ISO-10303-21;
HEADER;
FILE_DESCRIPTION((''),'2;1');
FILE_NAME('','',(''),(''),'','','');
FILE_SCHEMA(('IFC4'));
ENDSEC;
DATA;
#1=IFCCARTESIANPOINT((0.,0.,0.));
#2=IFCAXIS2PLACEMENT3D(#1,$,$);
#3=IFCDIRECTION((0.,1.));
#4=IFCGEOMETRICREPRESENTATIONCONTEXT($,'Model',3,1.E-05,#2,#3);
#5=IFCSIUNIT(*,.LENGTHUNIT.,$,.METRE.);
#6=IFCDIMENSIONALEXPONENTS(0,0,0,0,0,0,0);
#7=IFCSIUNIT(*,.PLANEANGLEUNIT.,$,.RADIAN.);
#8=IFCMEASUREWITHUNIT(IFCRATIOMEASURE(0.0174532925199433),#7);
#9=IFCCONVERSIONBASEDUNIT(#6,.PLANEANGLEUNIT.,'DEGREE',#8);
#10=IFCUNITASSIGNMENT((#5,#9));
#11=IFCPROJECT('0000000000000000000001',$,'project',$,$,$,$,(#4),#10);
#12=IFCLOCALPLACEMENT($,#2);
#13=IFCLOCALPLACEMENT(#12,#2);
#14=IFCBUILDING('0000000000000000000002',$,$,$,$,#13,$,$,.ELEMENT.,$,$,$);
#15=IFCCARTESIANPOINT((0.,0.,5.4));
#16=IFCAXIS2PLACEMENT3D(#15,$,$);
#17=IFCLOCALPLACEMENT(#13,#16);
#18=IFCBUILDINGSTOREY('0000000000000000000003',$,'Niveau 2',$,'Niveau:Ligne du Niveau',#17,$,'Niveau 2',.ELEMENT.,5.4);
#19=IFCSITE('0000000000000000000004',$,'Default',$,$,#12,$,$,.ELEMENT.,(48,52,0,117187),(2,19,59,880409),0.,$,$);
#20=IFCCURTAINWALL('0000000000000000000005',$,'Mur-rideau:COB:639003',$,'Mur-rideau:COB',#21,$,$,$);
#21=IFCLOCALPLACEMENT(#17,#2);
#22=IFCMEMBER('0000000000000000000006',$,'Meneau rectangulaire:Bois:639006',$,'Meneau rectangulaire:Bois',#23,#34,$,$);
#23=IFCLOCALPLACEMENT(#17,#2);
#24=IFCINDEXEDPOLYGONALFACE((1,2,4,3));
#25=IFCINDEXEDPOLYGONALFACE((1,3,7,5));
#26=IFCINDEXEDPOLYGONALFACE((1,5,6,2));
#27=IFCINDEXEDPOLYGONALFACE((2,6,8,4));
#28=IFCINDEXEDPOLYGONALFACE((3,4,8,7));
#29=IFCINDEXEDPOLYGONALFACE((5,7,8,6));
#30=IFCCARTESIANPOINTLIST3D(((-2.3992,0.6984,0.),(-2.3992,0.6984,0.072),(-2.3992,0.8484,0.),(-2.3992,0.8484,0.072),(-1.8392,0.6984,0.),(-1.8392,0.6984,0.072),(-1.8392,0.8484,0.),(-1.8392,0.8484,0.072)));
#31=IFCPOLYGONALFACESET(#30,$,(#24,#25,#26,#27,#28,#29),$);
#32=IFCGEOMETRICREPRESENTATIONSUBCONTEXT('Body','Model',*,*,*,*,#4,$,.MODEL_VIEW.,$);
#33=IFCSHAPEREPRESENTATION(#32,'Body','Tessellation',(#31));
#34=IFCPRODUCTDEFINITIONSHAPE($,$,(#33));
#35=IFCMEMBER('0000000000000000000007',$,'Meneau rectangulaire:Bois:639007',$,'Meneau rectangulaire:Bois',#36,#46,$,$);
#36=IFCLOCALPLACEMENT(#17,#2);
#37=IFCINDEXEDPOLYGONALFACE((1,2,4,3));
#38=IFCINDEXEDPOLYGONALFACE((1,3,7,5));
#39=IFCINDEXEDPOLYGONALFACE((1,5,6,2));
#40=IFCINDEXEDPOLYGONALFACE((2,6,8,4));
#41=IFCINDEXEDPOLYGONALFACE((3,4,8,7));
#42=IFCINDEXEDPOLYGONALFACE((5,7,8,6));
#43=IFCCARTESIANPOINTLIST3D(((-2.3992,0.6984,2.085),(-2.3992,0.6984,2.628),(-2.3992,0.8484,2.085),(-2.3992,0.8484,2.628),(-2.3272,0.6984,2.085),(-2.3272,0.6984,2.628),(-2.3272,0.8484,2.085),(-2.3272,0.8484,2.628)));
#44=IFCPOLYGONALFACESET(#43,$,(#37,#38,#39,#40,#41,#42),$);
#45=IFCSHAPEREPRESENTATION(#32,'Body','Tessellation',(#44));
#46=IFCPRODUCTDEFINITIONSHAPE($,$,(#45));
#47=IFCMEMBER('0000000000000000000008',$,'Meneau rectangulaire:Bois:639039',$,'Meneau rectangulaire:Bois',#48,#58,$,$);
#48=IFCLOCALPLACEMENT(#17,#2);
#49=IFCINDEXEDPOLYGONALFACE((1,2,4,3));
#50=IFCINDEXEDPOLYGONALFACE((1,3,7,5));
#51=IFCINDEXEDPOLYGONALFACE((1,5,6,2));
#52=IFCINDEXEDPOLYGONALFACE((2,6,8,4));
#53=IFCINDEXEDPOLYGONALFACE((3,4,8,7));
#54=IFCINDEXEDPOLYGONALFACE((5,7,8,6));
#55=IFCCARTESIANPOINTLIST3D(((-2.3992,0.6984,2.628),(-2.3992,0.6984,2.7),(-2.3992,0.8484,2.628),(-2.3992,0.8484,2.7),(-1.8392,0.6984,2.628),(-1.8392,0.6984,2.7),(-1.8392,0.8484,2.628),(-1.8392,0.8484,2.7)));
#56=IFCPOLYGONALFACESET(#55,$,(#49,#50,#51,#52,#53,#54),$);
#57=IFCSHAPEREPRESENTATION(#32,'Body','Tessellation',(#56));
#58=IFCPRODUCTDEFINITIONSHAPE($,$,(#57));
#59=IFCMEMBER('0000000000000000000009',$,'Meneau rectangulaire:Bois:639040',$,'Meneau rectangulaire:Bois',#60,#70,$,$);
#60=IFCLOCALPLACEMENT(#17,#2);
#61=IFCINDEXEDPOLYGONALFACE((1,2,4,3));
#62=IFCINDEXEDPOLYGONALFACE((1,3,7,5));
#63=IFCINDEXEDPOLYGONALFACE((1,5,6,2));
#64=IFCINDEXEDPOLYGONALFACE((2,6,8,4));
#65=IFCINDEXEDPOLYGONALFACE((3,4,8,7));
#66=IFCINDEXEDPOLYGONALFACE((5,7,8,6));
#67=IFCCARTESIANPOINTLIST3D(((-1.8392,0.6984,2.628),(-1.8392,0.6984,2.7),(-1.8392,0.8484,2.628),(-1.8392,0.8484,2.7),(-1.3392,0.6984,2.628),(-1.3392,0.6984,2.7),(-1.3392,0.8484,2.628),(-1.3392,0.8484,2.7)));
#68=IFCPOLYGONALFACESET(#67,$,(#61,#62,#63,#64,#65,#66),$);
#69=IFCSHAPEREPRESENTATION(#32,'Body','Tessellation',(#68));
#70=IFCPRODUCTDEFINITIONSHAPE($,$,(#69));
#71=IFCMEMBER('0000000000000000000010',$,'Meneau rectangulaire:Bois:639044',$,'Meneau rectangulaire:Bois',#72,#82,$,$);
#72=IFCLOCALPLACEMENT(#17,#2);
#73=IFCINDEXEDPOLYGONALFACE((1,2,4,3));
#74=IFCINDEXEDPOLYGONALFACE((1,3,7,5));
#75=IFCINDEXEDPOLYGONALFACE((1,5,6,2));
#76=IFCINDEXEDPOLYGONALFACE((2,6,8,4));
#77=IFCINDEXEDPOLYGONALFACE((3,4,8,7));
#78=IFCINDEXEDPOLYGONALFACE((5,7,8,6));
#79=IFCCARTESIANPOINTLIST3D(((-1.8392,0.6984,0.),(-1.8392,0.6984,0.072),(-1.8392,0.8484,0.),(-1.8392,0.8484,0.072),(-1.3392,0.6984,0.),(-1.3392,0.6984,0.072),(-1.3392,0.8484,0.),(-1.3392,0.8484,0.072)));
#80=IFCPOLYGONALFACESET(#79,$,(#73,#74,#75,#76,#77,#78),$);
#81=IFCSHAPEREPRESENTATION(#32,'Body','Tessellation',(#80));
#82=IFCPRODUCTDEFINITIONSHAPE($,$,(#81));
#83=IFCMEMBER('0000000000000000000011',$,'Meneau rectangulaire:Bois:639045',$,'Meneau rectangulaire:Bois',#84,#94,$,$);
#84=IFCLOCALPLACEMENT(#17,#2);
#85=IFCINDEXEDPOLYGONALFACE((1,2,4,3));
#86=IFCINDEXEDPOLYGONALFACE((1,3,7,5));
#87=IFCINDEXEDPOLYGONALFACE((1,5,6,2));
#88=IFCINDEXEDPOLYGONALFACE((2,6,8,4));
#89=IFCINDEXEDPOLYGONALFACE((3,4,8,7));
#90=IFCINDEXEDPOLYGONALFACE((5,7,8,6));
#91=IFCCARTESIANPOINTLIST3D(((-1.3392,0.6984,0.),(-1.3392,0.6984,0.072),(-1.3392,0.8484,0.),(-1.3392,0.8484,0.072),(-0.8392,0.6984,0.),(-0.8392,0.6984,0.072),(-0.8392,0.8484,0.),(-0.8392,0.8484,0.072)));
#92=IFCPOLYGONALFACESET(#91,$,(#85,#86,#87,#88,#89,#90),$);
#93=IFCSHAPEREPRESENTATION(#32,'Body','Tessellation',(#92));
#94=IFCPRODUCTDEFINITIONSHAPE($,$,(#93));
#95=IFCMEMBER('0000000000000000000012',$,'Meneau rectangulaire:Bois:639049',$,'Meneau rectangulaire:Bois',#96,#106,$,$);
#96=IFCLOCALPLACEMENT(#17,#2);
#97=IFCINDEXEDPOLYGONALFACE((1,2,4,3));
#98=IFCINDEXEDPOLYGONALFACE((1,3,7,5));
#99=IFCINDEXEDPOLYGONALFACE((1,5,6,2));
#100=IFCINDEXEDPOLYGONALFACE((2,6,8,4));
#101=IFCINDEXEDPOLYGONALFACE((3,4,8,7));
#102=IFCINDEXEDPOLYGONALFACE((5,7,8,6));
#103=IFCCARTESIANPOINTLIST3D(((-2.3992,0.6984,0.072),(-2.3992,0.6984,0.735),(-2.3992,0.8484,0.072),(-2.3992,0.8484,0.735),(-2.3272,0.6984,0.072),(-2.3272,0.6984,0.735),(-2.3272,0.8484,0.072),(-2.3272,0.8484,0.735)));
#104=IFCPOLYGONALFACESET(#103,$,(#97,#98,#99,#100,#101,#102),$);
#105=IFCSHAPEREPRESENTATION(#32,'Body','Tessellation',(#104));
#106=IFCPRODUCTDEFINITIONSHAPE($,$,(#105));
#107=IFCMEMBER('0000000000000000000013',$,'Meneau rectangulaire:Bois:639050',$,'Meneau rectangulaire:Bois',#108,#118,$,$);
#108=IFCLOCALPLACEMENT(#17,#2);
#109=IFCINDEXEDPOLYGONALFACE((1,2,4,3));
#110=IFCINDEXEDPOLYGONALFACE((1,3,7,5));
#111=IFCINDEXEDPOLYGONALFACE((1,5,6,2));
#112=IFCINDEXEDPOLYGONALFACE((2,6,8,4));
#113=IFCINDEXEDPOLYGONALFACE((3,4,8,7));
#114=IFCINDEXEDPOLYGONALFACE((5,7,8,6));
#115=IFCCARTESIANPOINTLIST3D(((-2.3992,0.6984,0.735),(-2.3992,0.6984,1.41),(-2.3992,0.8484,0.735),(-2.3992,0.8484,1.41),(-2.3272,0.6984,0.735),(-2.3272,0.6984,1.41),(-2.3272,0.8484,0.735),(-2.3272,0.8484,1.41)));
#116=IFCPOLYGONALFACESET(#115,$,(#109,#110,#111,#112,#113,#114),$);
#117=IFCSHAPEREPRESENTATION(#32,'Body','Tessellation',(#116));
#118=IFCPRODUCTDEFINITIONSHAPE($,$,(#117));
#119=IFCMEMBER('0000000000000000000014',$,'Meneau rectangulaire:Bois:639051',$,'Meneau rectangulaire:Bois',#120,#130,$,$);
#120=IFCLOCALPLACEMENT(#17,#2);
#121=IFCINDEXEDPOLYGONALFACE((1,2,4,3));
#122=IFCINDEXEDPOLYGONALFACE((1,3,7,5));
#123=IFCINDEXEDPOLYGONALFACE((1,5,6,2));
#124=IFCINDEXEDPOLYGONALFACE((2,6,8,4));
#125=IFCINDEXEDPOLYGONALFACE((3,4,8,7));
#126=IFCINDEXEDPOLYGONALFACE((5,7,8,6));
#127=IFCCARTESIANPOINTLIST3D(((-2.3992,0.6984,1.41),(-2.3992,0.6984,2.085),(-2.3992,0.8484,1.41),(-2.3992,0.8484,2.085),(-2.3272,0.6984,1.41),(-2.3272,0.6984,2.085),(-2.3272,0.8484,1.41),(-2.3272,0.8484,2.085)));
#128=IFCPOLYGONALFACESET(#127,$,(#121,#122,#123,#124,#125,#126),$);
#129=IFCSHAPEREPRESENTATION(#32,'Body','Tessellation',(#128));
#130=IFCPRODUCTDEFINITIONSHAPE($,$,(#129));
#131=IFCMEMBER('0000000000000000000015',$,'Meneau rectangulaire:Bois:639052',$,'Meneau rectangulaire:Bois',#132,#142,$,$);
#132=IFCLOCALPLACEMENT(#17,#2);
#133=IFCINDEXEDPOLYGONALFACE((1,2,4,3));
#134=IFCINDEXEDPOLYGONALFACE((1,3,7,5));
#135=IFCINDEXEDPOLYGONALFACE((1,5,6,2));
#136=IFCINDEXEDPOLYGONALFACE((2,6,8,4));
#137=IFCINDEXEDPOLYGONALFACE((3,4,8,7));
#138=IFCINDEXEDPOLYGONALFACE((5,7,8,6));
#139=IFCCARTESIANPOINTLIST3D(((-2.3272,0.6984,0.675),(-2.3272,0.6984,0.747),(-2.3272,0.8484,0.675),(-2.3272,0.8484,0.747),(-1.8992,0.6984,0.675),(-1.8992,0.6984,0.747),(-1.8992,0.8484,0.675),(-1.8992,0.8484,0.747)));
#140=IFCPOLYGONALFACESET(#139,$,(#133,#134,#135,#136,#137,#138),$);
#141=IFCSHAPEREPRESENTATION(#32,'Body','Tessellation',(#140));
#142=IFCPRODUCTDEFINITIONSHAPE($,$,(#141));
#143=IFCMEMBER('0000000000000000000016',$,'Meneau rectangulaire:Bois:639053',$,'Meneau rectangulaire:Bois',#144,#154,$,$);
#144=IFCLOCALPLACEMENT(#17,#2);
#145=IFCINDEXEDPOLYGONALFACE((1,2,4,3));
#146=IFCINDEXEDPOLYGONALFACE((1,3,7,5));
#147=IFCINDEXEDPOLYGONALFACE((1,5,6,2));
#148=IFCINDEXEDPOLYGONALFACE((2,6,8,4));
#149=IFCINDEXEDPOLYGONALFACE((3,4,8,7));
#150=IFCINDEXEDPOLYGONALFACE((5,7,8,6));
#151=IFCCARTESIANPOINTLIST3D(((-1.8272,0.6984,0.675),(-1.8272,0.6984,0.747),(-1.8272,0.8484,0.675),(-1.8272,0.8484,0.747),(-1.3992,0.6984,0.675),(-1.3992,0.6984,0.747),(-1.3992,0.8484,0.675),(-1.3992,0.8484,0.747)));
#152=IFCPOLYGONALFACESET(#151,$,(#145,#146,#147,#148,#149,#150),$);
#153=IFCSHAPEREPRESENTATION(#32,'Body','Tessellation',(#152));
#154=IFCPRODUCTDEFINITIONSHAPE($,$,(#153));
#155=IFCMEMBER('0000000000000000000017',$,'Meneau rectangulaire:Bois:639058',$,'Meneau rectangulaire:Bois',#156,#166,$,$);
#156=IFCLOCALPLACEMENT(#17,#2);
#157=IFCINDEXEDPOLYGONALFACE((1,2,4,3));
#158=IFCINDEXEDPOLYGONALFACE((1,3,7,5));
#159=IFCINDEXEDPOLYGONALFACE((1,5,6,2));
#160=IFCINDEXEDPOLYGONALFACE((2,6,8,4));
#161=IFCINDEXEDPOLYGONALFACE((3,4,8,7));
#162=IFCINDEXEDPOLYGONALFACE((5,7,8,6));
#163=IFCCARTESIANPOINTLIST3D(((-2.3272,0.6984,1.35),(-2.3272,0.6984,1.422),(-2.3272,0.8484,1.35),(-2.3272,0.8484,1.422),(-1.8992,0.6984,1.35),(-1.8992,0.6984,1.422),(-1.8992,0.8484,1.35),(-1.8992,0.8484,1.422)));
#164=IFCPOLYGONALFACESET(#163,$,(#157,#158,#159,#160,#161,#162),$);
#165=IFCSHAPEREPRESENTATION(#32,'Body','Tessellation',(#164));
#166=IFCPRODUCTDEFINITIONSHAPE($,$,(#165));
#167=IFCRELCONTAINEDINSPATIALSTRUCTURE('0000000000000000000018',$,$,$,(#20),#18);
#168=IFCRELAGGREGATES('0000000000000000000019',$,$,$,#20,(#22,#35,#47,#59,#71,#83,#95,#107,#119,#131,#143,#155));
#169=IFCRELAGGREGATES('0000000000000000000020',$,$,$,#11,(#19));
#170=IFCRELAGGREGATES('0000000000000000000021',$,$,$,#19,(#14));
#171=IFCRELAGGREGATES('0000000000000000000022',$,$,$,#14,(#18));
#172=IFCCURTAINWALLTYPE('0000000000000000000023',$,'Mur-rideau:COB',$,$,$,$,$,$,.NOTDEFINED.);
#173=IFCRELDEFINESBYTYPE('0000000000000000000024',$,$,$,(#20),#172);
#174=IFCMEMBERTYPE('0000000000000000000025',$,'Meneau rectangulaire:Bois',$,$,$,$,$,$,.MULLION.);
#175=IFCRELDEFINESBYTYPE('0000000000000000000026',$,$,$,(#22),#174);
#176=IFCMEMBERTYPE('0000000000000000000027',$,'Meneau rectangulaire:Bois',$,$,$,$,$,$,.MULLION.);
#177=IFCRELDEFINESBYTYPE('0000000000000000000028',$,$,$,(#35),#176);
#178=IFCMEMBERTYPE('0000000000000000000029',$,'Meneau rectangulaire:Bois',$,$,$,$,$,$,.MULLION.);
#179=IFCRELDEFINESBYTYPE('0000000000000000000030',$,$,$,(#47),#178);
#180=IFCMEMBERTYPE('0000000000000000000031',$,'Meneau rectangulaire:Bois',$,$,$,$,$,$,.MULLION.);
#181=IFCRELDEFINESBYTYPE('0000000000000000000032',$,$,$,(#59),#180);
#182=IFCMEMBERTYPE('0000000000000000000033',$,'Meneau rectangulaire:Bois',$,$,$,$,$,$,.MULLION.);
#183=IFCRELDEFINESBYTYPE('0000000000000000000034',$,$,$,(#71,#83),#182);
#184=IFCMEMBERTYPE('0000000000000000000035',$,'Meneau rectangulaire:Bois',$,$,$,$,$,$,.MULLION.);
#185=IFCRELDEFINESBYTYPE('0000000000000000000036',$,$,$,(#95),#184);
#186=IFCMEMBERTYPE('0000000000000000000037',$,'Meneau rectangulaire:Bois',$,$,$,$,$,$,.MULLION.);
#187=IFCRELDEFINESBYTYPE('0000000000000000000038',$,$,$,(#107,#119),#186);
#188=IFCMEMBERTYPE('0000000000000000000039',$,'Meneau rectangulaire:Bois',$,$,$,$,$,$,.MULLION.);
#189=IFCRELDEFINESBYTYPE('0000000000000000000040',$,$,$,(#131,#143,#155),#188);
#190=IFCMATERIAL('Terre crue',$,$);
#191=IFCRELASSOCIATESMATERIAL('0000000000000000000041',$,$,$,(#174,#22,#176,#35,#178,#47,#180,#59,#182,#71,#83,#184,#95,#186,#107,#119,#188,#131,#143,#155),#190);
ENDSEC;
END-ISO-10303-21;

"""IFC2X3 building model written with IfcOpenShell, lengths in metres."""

from ifc_helpers import new_model, entity, si_unit, converted_unit, direction, frame, origin, origin_2d_with_axis, place, context, subcontext, project, spatial, rectangle, extrude, source, transform, mapped, material, type_object, type_shapes, element, aggregate, save


model = new_model("IFC2X3")

# Units and contexts
model_context = context("Model", 3, precision=1e-05, world=origin(), true_north=direction((0.0, 1.0)))
body_context = subcontext(model_context, "Body", "Model", "MODEL_VIEW")
ifc_project = project(units=[si_unit("LENGTHUNIT", "METRE"), converted_unit("PLANEANGLEUNIT", "DEGREE", entity("IfcRatioMeasure", 0.0174532925199433), si_unit("PLANEANGLEUNIT", "RADIAN"), dimensions=[0, 0, 0, 0, 0, 0, 0])], contexts=[model_context])

# Site, building, storey
site_placement = place(None, origin())
site = spatial("IfcSite", under=ifc_project, at=site_placement, Name="Default", CompositionType="ELEMENT", RefLatitude=(48, 52, 0, 117187), RefLongitude=(2, 19, 59, 880409), RefElevation=0.0)
building_placement = place(site_placement, origin())
building = spatial("IfcBuilding", under=site, at=building_placement, CompositionType="ELEMENT")
storey_placement = place(building_placement, frame((0.0, 0.0, 5.4)))
storey = spatial("IfcBuildingStorey", under=building, at=storey_placement, Name="Niveau 2", ObjectType="Niveau:Ligne du Niveau", LongName="Niveau 2", CompositionType="ELEMENT", Elevation=5.4)

# Curtain wall, members
curtain_wall_type_1 = type_object("IfcCurtainWallType", Name="Mur-rideau:COB", PredefinedType="NOTDEFINED")
curtain_wall_1_placement = place(storey_placement, frame((0.0, 0.0, -5.4)))
curtain_wall_1 = element("IfcCurtainWall", 1, at=curtain_wall_1_placement, inside=storey, type_object=curtain_wall_type_1, Name="Mur-rideau:COB:639003", ObjectType="Mur-rideau:COB")
ifc_material_1 = material(Name="Terre crue")
member_type_1 = type_object("IfcMemberType", Name="Meneau rectangulaire:Bois", PredefinedType="MULLION", material=ifc_material_1)
shared_shape_1 = source(origin(), body_context, "Body", "SweptSolid", [
    extrude(rectangle(XDim=0.15, YDim=0.072, at=origin_2d_with_axis()), frame((-0.036, 0.0, -0.56), z_axis=(0.0, 0.0, 1.0), x_axis=(0.0, -1.0, 0.0)), (0.0, 0.0, 1.0), 0.56),
])
type_shapes(member_type_1, [shared_shape_1])
member_1_placement = place(storey_placement, frame((-2.3992, 0.7734, 0.0), z_axis=(-1.0, 0.0, 0.0), x_axis=(0.0, 0.0, -1.0)))
member_1 = element("IfcMember", 2, at=member_1_placement, type_object=member_type_1, material=ifc_material_1, Name="Meneau rectangulaire:Bois:639006", ObjectType="Meneau rectangulaire:Bois", context=body_context, shape_type="MappedRepresentation", body=[
    mapped(shared_shape_1, transform((0.0, 0.0, 0.0), scale=1.0)),
])
member_type_2 = type_object("IfcMemberType", Name="Meneau rectangulaire:Bois", PredefinedType="MULLION", material=ifc_material_1)
shared_shape_2 = source(origin(), body_context, "Body", "SweptSolid", [
    extrude(rectangle(XDim=0.15, YDim=0.072, at=origin_2d_with_axis()), frame((-0.036, 0.0, -0.543), z_axis=(0.0, 0.0, 1.0), x_axis=(0.0, -1.0, 0.0)), (0.0, 0.0, 1.0), 0.543),
])
type_shapes(member_type_2, [shared_shape_2])
member_2_placement = place(storey_placement, frame((-2.3992, 0.7734, 2.628), z_axis=(0.0, 0.0, 1.0), x_axis=(-1.0, 0.0, 0.0)))
member_2 = element("IfcMember", 3, at=member_2_placement, type_object=member_type_2, material=ifc_material_1, Name="Meneau rectangulaire:Bois:639007", ObjectType="Meneau rectangulaire:Bois", context=body_context, shape_type="MappedRepresentation", body=[
    mapped(shared_shape_2, transform((0.0, 0.0, 0.0), scale=1.0)),
])
member_type_3 = type_object("IfcMemberType", Name="Meneau rectangulaire:Bois", PredefinedType="MULLION", material=ifc_material_1)
shared_shape_3 = source(origin(), body_context, "Body", "SweptSolid", [
    extrude(rectangle(XDim=0.15, YDim=0.072, at=origin_2d_with_axis()), frame((-0.036, 0.0, -0.56), z_axis=(0.0, 0.0, 1.0), x_axis=(0.0, -1.0, 0.0)), (0.0, 0.0, 1.0), 0.56),
])
type_shapes(member_type_3, [shared_shape_3])
member_3_placement = place(storey_placement, frame((-1.8392, 0.7734, 2.7), z_axis=(1.0, 0.0, 0.0), x_axis=(0.0, 0.0, 1.0)))
member_3 = element("IfcMember", 4, at=member_3_placement, type_object=member_type_3, material=ifc_material_1, Name="Meneau rectangulaire:Bois:639039", ObjectType="Meneau rectangulaire:Bois", context=body_context, shape_type="MappedRepresentation", body=[
    mapped(shared_shape_3, transform((0.0, 0.0, 0.0), scale=1.0)),
])
member_type_4 = type_object("IfcMemberType", Name="Meneau rectangulaire:Bois", PredefinedType="MULLION", material=ifc_material_1)
shared_shape_4 = source(origin(), body_context, "Body", "SweptSolid", [
    extrude(rectangle(XDim=0.15, YDim=0.072, at=origin_2d_with_axis()), frame((-0.036, 0.0, -0.5), z_axis=(0.0, 0.0, 1.0), x_axis=(0.0, -1.0, 0.0)), (0.0, 0.0, 1.0), 0.5),
])
type_shapes(member_type_4, [shared_shape_4])
member_4_placement = place(storey_placement, frame((-1.3392, 0.7734, 2.7), z_axis=(1.0, 0.0, 0.0), x_axis=(0.0, 0.0, 1.0)))
member_4 = element("IfcMember", 5, at=member_4_placement, type_object=member_type_4, material=ifc_material_1, Name="Meneau rectangulaire:Bois:639040", ObjectType="Meneau rectangulaire:Bois", context=body_context, shape_type="MappedRepresentation", body=[
    mapped(shared_shape_4, transform((0.0, 0.0, 0.0), scale=1.0)),
])
member_type_5 = type_object("IfcMemberType", Name="Meneau rectangulaire:Bois", PredefinedType="MULLION", material=ifc_material_1)
shared_shape_5 = source(origin(), body_context, "Body", "SweptSolid", [
    extrude(rectangle(XDim=0.15, YDim=0.072, at=origin_2d_with_axis()), frame((-0.036, 0.0, -0.5), z_axis=(0.0, 0.0, 1.0), x_axis=(0.0, -1.0, 0.0)), (0.0, 0.0, 1.0), 0.5),
])
type_shapes(member_type_5, [shared_shape_5])
member_5_placement = place(storey_placement, frame((-1.8392, 0.7734, 0.0), z_axis=(-1.0, 0.0, 0.0), x_axis=(0.0, 0.0, -1.0)))
member_5 = element("IfcMember", 6, at=member_5_placement, type_object=member_type_5, material=ifc_material_1, Name="Meneau rectangulaire:Bois:639044", ObjectType="Meneau rectangulaire:Bois", context=body_context, shape_type="MappedRepresentation", body=[
    mapped(shared_shape_5, transform((0.0, 0.0, 0.0), scale=1.0)),
])
member_6_placement = place(storey_placement, frame((-1.3392, 0.7734, 0.0), z_axis=(-1.0, 0.0, 0.0), x_axis=(0.0, 0.0, -1.0)))
member_6 = element("IfcMember", 7, at=member_6_placement, type_object=member_type_5, material=ifc_material_1, Name="Meneau rectangulaire:Bois:639045", ObjectType="Meneau rectangulaire:Bois", context=body_context, shape_type="MappedRepresentation", body=[
    mapped(shared_shape_5, transform((0.0, 0.0, 0.0), scale=1.0)),
])
member_type_6 = type_object("IfcMemberType", Name="Meneau rectangulaire:Bois", PredefinedType="MULLION", material=ifc_material_1)
shared_shape_6 = source(origin(), body_context, "Body", "SweptSolid", [
    extrude(rectangle(XDim=0.15, YDim=0.072, at=origin_2d_with_axis()), frame((-0.036, 0.0, -0.663), z_axis=(0.0, 0.0, 1.0), x_axis=(0.0, -1.0, 0.0)), (0.0, 0.0, 1.0), 0.663),
])
type_shapes(member_type_6, [shared_shape_6])
member_7_placement = place(storey_placement, frame((-2.3992, 0.7734, 0.735), z_axis=(0.0, 0.0, 1.0), x_axis=(-1.0, 0.0, 0.0)))
member_7 = element("IfcMember", 8, at=member_7_placement, type_object=member_type_6, material=ifc_material_1, Name="Meneau rectangulaire:Bois:639049", ObjectType="Meneau rectangulaire:Bois", context=body_context, shape_type="MappedRepresentation", body=[
    mapped(shared_shape_6, transform((0.0, 0.0, 0.0), scale=1.0)),
])
member_type_7 = type_object("IfcMemberType", Name="Meneau rectangulaire:Bois", PredefinedType="MULLION", material=ifc_material_1)
shared_shape_7 = source(origin(), body_context, "Body", "SweptSolid", [
    extrude(rectangle(XDim=0.15, YDim=0.072, at=origin_2d_with_axis()), frame((-0.036, 0.0, -0.675), z_axis=(0.0, 0.0, 1.0), x_axis=(0.0, -1.0, 0.0)), (0.0, 0.0, 1.0), 0.675),
])
type_shapes(member_type_7, [shared_shape_7])
member_8_placement = place(storey_placement, frame((-2.3992, 0.7734, 1.41), z_axis=(0.0, 0.0, 1.0), x_axis=(-1.0, 0.0, 0.0)))
member_8 = element("IfcMember", 9, at=member_8_placement, type_object=member_type_7, material=ifc_material_1, Name="Meneau rectangulaire:Bois:639050", ObjectType="Meneau rectangulaire:Bois", context=body_context, shape_type="MappedRepresentation", body=[
    mapped(shared_shape_7, transform((0.0, 0.0, 0.0), scale=1.0)),
])
member_9_placement = place(storey_placement, frame((-2.3992, 0.7734, 2.085), z_axis=(0.0, 0.0, 1.0), x_axis=(-1.0, 0.0, 0.0)))
member_9 = element("IfcMember", 10, at=member_9_placement, type_object=member_type_7, material=ifc_material_1, Name="Meneau rectangulaire:Bois:639051", ObjectType="Meneau rectangulaire:Bois", context=body_context, shape_type="MappedRepresentation", body=[
    mapped(shared_shape_7, transform((0.0, 0.0, 0.0), scale=1.0)),
])
member_type_8 = type_object("IfcMemberType", Name="Meneau rectangulaire:Bois", PredefinedType="MULLION", material=ifc_material_1)
shared_shape_8 = source(origin(), body_context, "Body", "SweptSolid", [
    extrude(rectangle(XDim=0.15, YDim=0.072, at=origin_2d_with_axis()), frame((-0.024, 0.0, -0.428), z_axis=(0.0, 0.0, 1.0), x_axis=(0.0, -1.0, 0.0)), (0.0, 0.0, 1.0), 0.428),
])
type_shapes(member_type_8, [shared_shape_8])
member_10_placement = place(storey_placement, frame((-1.8992, 0.7734, 0.735), z_axis=(1.0, 0.0, 0.0), x_axis=(0.0, 0.0, 1.0)))
member_10 = element("IfcMember", 11, at=member_10_placement, type_object=member_type_8, material=ifc_material_1, Name="Meneau rectangulaire:Bois:639052", ObjectType="Meneau rectangulaire:Bois", context=body_context, shape_type="MappedRepresentation", body=[
    mapped(shared_shape_8, transform((0.0, 0.0, 0.0), scale=1.0)),
])
member_11_placement = place(storey_placement, frame((-1.3992, 0.7734, 0.735), z_axis=(1.0, 0.0, 0.0), x_axis=(0.0, 0.0, 1.0)))
member_11 = element("IfcMember", 12, at=member_11_placement, type_object=member_type_8, material=ifc_material_1, Name="Meneau rectangulaire:Bois:639053", ObjectType="Meneau rectangulaire:Bois", context=body_context, shape_type="MappedRepresentation", body=[
    mapped(shared_shape_8, transform((0.0, 0.0, 0.0), scale=1.0)),
])
member_12_placement = place(storey_placement, frame((-1.8992, 0.7734, 1.41), z_axis=(1.0, 0.0, 0.0), x_axis=(0.0, 0.0, 1.0)))
member_12 = element("IfcMember", 13, at=member_12_placement, type_object=member_type_8, material=ifc_material_1, Name="Meneau rectangulaire:Bois:639058", ObjectType="Meneau rectangulaire:Bois", context=body_context, shape_type="MappedRepresentation", body=[
    mapped(shared_shape_8, transform((0.0, 0.0, 0.0), scale=1.0)),
])
aggregate(curtain_wall_1, [member_1, member_2, member_3, member_4, member_5, member_6, member_7, member_8, member_9, member_10, member_11, member_12])

save(model, "model.ifc")
